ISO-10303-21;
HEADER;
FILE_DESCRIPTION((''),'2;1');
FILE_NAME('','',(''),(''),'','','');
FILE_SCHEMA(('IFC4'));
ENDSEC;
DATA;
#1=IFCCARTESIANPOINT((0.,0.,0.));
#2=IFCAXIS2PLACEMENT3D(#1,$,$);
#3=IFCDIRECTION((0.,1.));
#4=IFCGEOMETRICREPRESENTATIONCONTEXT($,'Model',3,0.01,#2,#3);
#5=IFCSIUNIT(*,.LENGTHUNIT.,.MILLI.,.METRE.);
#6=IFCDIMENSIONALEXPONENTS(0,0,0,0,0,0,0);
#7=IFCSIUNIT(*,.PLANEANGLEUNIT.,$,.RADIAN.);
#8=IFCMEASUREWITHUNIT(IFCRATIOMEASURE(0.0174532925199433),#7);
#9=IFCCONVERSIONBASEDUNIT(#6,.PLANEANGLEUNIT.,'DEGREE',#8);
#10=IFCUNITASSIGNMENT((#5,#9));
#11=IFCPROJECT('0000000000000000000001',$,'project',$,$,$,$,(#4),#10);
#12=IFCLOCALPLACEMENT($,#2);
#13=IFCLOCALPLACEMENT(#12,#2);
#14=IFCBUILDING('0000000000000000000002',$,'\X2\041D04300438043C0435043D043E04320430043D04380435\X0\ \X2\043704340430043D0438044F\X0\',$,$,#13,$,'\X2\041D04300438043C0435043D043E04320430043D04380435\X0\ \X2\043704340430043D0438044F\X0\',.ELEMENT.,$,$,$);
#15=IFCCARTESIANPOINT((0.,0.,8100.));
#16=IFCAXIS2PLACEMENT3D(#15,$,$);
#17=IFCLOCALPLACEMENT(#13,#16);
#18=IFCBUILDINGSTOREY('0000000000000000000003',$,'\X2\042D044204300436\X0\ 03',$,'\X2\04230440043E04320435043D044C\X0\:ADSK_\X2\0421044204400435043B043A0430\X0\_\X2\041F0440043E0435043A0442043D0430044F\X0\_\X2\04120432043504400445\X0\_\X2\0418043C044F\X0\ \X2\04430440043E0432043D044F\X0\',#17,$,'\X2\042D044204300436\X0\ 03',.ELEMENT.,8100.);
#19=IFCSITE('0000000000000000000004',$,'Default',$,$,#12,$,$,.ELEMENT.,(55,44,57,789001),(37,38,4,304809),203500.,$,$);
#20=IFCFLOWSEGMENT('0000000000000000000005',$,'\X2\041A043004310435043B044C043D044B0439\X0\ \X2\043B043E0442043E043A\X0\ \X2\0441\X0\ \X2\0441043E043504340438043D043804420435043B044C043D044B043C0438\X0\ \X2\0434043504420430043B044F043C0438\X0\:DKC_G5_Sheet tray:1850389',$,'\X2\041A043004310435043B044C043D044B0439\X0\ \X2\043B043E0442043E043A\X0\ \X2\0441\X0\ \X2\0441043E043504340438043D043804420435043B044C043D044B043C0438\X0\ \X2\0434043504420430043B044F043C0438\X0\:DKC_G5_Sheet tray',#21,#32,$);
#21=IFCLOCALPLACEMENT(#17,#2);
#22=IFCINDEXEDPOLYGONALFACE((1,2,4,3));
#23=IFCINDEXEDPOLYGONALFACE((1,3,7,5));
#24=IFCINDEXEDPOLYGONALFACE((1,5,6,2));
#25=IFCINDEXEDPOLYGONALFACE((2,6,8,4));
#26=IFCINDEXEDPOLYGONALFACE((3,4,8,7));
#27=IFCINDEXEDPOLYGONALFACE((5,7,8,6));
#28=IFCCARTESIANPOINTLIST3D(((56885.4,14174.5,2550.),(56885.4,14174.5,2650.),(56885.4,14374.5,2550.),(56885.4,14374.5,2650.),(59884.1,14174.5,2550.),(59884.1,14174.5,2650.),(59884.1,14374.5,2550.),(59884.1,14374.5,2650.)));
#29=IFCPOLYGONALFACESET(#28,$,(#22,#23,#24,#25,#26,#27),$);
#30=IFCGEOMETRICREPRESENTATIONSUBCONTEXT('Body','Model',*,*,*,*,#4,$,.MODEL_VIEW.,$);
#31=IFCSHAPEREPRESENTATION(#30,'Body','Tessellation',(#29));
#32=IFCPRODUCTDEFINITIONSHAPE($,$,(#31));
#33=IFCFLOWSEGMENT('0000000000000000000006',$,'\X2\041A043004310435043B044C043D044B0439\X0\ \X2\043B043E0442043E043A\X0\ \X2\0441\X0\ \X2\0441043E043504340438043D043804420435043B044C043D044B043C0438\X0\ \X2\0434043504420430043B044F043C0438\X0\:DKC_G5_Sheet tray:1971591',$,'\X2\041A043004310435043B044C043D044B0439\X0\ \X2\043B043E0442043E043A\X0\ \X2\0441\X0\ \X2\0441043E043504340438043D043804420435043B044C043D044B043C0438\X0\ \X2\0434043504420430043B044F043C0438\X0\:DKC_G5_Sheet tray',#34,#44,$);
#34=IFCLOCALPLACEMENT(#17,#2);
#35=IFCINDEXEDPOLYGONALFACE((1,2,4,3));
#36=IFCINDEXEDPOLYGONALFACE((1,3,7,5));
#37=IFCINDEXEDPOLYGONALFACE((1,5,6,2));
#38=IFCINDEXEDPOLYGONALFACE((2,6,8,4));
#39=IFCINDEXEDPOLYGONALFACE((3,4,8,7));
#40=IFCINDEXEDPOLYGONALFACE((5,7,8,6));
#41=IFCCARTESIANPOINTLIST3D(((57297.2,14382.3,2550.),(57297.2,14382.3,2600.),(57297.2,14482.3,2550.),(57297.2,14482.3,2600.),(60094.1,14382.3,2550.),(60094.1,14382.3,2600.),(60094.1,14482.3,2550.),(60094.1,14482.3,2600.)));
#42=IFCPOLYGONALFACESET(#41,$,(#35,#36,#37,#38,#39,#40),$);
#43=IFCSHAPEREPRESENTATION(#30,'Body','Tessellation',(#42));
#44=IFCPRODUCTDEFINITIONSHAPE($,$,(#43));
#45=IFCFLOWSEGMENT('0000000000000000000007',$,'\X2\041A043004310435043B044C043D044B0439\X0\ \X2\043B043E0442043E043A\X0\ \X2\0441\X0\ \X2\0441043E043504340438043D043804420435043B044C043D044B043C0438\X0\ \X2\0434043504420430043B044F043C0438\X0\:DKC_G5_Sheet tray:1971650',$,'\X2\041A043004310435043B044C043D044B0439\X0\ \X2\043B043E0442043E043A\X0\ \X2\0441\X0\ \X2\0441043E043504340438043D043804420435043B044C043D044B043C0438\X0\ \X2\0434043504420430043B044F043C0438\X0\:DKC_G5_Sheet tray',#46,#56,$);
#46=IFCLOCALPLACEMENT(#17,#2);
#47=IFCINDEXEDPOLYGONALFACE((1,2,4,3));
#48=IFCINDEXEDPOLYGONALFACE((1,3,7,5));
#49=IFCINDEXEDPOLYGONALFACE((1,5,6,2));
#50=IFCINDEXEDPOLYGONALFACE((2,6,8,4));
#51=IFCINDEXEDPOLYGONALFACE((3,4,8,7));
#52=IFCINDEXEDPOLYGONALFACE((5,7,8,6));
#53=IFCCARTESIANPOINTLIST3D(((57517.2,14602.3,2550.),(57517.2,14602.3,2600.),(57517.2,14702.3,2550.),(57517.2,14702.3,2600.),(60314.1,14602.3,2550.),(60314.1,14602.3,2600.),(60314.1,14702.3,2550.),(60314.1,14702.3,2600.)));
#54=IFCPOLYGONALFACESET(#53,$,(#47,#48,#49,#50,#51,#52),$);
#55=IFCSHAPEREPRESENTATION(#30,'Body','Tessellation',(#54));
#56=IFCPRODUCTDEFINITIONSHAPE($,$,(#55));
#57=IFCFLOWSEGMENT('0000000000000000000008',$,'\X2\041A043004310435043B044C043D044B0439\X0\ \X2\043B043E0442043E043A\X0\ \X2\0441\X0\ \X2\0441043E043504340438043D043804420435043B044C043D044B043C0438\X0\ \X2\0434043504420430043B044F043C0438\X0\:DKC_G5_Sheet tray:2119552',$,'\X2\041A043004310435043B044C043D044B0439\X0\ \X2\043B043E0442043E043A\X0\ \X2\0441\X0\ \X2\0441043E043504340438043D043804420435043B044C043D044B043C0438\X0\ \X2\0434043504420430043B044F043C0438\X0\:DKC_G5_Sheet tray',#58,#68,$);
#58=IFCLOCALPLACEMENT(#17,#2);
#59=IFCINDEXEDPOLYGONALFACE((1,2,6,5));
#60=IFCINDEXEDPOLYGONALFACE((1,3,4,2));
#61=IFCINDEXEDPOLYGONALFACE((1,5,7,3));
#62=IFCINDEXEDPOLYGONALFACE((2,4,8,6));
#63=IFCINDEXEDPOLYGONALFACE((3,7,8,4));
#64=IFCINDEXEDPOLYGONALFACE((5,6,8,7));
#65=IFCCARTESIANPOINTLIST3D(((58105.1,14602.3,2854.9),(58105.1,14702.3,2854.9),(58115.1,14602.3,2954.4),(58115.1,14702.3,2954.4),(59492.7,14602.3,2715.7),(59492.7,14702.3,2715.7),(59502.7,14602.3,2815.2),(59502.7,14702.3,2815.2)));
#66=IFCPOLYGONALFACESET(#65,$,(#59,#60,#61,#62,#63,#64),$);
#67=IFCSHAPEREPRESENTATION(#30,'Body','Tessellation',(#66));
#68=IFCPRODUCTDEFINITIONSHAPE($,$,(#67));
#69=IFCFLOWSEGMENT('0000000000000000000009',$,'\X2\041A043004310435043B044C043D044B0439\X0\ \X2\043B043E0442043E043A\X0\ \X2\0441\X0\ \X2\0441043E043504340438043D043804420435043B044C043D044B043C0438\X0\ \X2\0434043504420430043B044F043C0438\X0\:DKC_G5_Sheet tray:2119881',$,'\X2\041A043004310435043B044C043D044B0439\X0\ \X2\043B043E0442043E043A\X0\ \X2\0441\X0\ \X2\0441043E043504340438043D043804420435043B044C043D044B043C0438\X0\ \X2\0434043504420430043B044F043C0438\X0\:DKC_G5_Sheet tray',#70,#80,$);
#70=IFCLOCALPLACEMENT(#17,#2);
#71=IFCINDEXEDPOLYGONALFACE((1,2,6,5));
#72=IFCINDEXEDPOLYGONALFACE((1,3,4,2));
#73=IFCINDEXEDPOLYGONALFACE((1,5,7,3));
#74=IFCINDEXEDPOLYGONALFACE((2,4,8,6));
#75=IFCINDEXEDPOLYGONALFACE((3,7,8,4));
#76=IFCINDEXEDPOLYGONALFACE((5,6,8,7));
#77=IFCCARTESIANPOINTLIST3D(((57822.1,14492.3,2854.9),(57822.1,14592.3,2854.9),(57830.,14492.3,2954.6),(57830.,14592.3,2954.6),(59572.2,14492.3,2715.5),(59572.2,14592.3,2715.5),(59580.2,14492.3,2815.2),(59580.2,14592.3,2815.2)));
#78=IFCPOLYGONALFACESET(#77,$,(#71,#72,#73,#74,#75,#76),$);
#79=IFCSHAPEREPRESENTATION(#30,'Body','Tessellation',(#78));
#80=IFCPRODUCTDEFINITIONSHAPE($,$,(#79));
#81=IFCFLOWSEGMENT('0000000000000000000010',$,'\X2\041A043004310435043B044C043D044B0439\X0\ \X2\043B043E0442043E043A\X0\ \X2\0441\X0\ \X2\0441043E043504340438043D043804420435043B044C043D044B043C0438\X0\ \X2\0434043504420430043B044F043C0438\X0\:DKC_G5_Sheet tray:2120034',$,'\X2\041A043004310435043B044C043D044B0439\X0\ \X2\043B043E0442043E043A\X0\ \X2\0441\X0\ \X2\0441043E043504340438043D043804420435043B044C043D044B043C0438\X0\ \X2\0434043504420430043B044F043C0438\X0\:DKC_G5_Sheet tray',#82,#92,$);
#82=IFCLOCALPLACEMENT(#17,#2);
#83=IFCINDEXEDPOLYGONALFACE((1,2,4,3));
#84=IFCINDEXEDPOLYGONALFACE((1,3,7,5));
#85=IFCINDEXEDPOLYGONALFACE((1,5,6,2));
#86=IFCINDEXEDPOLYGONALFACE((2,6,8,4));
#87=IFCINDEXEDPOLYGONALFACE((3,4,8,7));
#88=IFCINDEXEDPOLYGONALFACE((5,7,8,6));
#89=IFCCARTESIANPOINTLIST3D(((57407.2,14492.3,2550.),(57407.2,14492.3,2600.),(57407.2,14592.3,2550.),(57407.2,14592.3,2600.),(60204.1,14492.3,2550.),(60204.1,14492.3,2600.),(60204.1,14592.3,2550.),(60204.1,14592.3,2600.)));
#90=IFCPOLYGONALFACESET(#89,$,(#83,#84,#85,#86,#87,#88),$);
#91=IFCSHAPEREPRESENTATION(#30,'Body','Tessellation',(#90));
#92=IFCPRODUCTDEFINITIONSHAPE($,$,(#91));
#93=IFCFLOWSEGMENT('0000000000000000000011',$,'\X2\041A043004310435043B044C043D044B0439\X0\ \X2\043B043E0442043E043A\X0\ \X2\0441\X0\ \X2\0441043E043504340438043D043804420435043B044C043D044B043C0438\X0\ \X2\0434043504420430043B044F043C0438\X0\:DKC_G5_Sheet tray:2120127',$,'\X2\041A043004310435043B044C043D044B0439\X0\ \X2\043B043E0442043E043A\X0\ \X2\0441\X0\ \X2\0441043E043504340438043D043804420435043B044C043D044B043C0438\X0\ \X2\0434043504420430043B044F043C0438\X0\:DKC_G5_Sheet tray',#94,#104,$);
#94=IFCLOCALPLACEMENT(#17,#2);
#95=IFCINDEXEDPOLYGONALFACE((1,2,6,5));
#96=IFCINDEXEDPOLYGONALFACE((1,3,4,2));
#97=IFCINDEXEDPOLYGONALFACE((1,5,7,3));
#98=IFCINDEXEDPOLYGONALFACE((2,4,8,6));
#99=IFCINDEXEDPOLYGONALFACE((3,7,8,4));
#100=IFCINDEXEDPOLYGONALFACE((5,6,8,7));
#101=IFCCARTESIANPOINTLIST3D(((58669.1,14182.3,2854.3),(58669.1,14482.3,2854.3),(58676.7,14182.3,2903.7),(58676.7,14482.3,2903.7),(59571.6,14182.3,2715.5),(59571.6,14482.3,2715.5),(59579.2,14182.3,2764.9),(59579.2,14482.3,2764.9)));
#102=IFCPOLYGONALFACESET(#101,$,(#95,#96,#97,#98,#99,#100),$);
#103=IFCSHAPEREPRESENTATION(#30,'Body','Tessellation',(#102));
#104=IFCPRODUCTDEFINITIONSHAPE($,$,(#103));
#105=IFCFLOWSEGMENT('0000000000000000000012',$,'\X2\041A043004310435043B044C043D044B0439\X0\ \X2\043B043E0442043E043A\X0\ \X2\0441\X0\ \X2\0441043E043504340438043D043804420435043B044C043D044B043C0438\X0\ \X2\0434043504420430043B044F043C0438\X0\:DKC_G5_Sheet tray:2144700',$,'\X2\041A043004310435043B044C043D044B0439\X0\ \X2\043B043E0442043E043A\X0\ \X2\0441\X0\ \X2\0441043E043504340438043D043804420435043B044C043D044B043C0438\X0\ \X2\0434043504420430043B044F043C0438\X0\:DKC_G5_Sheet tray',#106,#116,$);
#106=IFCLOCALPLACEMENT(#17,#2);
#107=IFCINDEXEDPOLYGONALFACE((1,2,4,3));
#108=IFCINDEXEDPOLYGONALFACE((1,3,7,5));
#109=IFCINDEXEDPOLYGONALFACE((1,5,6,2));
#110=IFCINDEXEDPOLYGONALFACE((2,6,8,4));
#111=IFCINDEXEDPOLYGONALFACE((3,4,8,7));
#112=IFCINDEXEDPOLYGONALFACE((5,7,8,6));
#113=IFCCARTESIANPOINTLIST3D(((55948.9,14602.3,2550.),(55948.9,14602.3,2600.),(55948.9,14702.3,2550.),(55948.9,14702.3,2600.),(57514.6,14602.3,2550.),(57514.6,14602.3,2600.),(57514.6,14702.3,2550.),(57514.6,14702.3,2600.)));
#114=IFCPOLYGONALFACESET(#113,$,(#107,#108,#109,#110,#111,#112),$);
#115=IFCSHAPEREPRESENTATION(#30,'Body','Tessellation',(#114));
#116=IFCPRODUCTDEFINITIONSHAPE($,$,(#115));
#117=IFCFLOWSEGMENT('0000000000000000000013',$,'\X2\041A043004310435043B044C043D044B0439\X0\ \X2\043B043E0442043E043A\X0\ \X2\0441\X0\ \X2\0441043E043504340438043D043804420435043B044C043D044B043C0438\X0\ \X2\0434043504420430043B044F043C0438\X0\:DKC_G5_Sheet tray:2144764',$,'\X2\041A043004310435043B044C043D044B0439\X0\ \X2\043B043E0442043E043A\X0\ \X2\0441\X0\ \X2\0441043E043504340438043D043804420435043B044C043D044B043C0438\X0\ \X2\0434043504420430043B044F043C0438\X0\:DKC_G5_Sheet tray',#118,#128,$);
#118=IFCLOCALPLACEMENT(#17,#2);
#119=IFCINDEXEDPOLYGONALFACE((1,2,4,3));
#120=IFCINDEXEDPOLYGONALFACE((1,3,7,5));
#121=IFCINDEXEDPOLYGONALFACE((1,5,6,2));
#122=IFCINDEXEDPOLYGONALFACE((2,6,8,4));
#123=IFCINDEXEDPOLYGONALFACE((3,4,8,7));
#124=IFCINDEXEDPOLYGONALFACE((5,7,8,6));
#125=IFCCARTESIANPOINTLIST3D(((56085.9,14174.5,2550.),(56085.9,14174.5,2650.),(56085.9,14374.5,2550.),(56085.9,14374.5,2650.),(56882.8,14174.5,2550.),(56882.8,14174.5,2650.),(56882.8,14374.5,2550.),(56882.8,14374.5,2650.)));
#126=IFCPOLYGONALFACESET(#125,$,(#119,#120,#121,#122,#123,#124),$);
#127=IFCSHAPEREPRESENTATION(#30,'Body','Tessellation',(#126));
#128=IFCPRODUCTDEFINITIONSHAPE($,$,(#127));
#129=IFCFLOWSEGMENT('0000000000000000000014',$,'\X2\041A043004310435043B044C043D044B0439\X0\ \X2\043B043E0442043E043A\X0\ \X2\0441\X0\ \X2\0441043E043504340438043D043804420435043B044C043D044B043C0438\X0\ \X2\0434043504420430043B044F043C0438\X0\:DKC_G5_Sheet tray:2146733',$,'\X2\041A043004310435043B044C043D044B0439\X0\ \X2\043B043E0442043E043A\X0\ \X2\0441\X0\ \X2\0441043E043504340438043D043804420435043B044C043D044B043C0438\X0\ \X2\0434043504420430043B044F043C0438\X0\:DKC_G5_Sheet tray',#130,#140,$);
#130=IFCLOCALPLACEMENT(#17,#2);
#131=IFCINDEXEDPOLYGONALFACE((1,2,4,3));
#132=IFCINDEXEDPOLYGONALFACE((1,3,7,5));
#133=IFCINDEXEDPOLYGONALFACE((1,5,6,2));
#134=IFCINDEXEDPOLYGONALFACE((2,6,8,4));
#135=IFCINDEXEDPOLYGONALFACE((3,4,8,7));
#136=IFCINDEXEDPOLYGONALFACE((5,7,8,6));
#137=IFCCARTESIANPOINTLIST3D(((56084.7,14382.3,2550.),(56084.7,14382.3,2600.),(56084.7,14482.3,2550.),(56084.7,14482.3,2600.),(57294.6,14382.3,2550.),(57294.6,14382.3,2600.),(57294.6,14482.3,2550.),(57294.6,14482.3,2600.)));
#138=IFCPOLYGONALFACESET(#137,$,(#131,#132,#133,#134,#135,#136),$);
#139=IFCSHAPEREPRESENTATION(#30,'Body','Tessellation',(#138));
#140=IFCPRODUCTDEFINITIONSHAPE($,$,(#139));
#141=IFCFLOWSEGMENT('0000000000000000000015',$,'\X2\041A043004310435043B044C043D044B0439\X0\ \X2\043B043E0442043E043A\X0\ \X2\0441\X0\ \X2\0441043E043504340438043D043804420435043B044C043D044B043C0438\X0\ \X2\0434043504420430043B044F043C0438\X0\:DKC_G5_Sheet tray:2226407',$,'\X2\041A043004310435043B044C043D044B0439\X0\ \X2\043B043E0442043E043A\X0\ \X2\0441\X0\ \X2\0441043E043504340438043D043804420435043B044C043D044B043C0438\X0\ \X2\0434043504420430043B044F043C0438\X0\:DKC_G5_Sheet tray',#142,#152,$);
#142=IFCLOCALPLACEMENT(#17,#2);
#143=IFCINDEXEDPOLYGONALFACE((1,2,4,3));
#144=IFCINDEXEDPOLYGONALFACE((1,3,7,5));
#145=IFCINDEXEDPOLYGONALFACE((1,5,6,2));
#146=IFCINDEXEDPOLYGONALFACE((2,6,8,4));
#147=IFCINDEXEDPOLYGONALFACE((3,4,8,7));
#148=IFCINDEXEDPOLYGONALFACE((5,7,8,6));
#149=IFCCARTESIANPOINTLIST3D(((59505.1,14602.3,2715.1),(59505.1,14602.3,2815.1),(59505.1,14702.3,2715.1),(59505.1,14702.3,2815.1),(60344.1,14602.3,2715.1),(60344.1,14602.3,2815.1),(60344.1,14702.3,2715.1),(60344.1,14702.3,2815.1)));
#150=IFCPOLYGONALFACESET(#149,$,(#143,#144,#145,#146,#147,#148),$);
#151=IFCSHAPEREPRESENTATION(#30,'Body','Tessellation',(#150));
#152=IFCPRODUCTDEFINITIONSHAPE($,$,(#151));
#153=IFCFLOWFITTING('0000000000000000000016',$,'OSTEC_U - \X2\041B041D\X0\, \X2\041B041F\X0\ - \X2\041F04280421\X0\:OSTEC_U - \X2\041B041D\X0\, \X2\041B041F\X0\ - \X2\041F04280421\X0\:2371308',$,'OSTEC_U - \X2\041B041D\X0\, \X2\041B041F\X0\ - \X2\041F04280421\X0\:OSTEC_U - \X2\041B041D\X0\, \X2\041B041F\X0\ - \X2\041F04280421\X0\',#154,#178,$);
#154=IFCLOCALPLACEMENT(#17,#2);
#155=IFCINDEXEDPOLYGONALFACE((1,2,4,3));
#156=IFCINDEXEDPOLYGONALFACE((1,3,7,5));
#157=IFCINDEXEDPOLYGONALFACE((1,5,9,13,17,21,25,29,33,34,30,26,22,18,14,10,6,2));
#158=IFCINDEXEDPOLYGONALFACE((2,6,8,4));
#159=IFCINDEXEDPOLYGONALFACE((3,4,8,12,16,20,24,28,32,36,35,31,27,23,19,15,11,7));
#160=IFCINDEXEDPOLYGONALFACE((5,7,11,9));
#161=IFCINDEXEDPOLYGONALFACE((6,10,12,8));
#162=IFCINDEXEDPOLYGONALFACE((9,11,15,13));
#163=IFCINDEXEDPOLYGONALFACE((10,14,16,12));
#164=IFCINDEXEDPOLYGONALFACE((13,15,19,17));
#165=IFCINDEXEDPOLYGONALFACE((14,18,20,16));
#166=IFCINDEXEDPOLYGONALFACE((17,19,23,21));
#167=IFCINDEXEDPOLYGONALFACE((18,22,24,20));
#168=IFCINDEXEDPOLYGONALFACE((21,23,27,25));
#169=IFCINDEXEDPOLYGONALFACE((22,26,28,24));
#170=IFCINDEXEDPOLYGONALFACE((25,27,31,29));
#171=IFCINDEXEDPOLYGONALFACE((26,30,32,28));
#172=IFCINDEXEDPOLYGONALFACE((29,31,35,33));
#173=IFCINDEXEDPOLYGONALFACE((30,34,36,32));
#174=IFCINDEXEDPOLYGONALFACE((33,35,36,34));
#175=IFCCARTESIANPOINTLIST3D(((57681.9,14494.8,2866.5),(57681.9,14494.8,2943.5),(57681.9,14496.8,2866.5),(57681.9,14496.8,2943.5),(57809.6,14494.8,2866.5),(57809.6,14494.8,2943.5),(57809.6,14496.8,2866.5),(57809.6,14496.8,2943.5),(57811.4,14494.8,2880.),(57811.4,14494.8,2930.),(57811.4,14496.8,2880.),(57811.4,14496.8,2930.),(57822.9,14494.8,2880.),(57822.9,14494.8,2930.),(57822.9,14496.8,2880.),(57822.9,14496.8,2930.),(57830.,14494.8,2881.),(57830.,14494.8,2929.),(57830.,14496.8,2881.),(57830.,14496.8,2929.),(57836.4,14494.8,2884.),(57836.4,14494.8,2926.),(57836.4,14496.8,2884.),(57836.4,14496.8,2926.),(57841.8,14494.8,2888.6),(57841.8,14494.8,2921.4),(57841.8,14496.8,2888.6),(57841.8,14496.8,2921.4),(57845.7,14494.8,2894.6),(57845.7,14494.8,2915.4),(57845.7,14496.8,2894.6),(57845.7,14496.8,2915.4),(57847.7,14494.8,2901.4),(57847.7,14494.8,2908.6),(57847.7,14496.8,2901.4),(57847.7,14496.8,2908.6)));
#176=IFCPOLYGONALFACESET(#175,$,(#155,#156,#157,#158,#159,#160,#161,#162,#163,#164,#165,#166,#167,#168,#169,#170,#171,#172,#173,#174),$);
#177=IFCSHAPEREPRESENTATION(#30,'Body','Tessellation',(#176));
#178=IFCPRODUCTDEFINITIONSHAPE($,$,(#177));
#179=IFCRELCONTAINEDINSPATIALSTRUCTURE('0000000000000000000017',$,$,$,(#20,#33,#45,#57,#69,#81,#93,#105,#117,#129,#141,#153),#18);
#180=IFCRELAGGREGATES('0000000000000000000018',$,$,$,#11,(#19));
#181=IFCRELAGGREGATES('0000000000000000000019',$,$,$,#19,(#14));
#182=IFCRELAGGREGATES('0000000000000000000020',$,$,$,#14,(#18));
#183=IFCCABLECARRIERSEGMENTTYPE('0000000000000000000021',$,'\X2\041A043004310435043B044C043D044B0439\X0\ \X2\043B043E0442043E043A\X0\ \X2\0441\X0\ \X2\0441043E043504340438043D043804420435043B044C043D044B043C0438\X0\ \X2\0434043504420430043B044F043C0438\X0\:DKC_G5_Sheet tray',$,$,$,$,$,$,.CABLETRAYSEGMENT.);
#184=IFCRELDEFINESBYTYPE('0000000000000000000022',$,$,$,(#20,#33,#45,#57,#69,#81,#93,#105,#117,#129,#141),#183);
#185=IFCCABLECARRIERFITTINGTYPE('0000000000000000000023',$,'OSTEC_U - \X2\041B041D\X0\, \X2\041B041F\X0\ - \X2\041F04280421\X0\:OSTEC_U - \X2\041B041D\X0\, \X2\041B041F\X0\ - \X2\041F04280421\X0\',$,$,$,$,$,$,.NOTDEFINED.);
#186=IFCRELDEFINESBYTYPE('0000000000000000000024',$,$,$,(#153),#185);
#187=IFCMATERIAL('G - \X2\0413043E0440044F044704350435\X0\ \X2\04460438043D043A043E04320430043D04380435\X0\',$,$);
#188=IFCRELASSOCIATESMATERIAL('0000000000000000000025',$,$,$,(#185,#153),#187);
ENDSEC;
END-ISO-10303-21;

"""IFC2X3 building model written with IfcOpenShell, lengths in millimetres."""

from ifc_helpers import new_model, entity, si_unit, converted_unit, direction, frame, frame_2d, origin, origin_2d_with_axis, place, context, subcontext, project, spatial, polyline, circle_curve, parameter, trimmed, segment, composite_curve, rectangle, outline, extrude, source, transform, mapped, material, type_object, type_shapes, element, save


model = new_model("IFC2X3")

# Units and contexts
model_context = context("Model", 3, precision=0.01, world=origin(), true_north=direction((0.0, 1.0)))
body_context = subcontext(model_context, "Body", "Model", "MODEL_VIEW")
ifc_project = project(units=[si_unit("LENGTHUNIT", "METRE", prefix="MILLI"), converted_unit("PLANEANGLEUNIT", "DEGREE", entity("IfcRatioMeasure", 0.0174532925199433), si_unit("PLANEANGLEUNIT", "RADIAN"), dimensions=[0, 0, 0, 0, 0, 0, 0])], contexts=[model_context])

# Site, building, storey
site_placement = place(None, frame((0.0, 0.0, 0.0)))
site = spatial("IfcSite", under=ifc_project, at=site_placement, Name="Default", CompositionType="ELEMENT", RefLatitude=(55, 44, 57, 789001), RefLongitude=(37, 38, 4, 304809), RefElevation=203500.0)
building_placement = place(site_placement, origin())
building = spatial("IfcBuilding", under=site, at=building_placement, Name="Наименование здания", LongName="Наименование здания", CompositionType="ELEMENT")
storey_placement = place(building_placement, frame((0.0, 0.0, 8100.0)))
storey = spatial("IfcBuildingStorey", under=building, at=storey_placement, Name="Этаж 03", ObjectType="Уровень:ADSK_Стрелка_Проектная_Вверх_Имя уровня", LongName="Этаж 03", CompositionType="ELEMENT", Elevation=8100.0)

# Flow segments
cable_carrier_segment_type = type_object("IfcCableCarrierSegmentType", Name="Кабельный лоток с соединительными деталями:DKC_G5_Sheet tray", PredefinedType="CABLETRAYSEGMENT")
flow_segment_1_placement = place(storey_placement, frame((56885.4, 14174.5, 2550.0)))
element("IfcFlowSegment", 1, at=flow_segment_1_placement, inside=storey, type_object=cable_carrier_segment_type, Name="Кабельный лоток с соединительными деталями:DKC_G5_Sheet tray:1850389", ObjectType="Кабельный лоток с соединительными деталями:DKC_G5_Sheet tray", context=body_context, shape_type="SweptSolid", body=[
    extrude(rectangle(XDim=2998.7, YDim=200.0, at=frame_2d((0.0, 0.0), x_axis=(1.0, 0.0))), frame((1499.4, 100.0, 0.0)), (0.0, 0.0, 1.0), 100.0),
])
flow_segment_2_placement = place(storey_placement, frame((57297.2, 14382.3, 2550.0)))
element("IfcFlowSegment", 2, at=flow_segment_2_placement, inside=storey, type_object=cable_carrier_segment_type, Name="Кабельный лоток с соединительными деталями:DKC_G5_Sheet tray:1971591", ObjectType="Кабельный лоток с соединительными деталями:DKC_G5_Sheet tray", context=body_context, shape_type="SweptSolid", body=[
    extrude(rectangle(XDim=2796.9, YDim=100.0, at=frame_2d((0.0, 0.0), x_axis=(1.0, 0.0))), frame((1398.5, 50.0, 0.0), z_axis=(0.0, 0.0, 1.0), x_axis=(-1.0, 0.0, 0.0)), (0.0, 0.0, 1.0), 50.0),
])
flow_segment_3_placement = place(storey_placement, frame((57517.2, 14602.3, 2550.0)))
element("IfcFlowSegment", 3, at=flow_segment_3_placement, inside=storey, type_object=cable_carrier_segment_type, Name="Кабельный лоток с соединительными деталями:DKC_G5_Sheet tray:1971650", ObjectType="Кабельный лоток с соединительными деталями:DKC_G5_Sheet tray", context=body_context, shape_type="SweptSolid", body=[
    extrude(rectangle(XDim=2796.9, YDim=100.0, at=frame_2d((0.0, 0.0), x_axis=(1.0, 0.0))), frame((1398.5, 50.0, 0.0), z_axis=(0.0, 0.0, 1.0), x_axis=(-1.0, 0.0, 0.0)), (0.0, 0.0, 1.0), 50.0),
])
flow_segment_4_placement = place(storey_placement, frame((58105.1, 14602.3, 2715.7)))
element("IfcFlowSegment", 4, at=flow_segment_4_placement, inside=storey, type_object=cable_carrier_segment_type, Name="Кабельный лоток с соединительными деталями:DKC_G5_Sheet tray:2119552", ObjectType="Кабельный лоток с соединительными деталями:DKC_G5_Sheet tray", context=body_context, shape_type="SweptSolid", body=[
    extrude(rectangle(XDim=100.0, YDim=100.0, at=frame_2d((0.0, 0.0), x_axis=(0.0, 1.0))), frame((5.0, 50.0, 188.9), z_axis=(0.995009, 0.0, -0.099785), x_axis=(0.0, 1.0, 0.0)), (0.0, 0.0, 1.0), 1394.6),
])
flow_segment_5_placement = place(storey_placement, frame((57822.1, 14492.3, 2715.5)))
element("IfcFlowSegment", 5, at=flow_segment_5_placement, inside=storey, type_object=cable_carrier_segment_type, Name="Кабельный лоток с соединительными деталями:DKC_G5_Sheet tray:2119881", ObjectType="Кабельный лоток с соединительными деталями:DKC_G5_Sheet tray", context=body_context, shape_type="SweptSolid", body=[
    extrude(rectangle(XDim=100.0, YDim=100.0, at=frame_2d((0.0, 0.0), x_axis=(0.0, 1.0))), frame((4.0, 50.0, 189.3), z_axis=(0.996841, 0.0, -0.079421), x_axis=(0.0, 1.0, 0.0)), (0.0, 0.0, 1.0), 1755.7),
])
flow_segment_6_placement = place(storey_placement, frame((57407.2, 14492.3, 2550.0)))
element("IfcFlowSegment", 6, at=flow_segment_6_placement, inside=storey, type_object=cable_carrier_segment_type, Name="Кабельный лоток с соединительными деталями:DKC_G5_Sheet tray:2120034", ObjectType="Кабельный лоток с соединительными деталями:DKC_G5_Sheet tray", context=body_context, shape_type="SweptSolid", body=[
    extrude(rectangle(XDim=2796.9, YDim=100.0, at=frame_2d((0.0, 0.0), x_axis=(1.0, 0.0))), frame((1398.5, 50.0, 0.0), z_axis=(0.0, 0.0, 1.0), x_axis=(-1.0, 0.0, 0.0)), (0.0, 0.0, 1.0), 50.0),
])
flow_segment_7_placement = place(storey_placement, frame((58669.1, 14182.3, 2715.5)))
element("IfcFlowSegment", 7, at=flow_segment_7_placement, inside=storey, type_object=cable_carrier_segment_type, Name="Кабельный лоток с соединительными деталями:DKC_G5_Sheet tray:2120127", ObjectType="Кабельный лоток с соединительными деталями:DKC_G5_Sheet tray", context=body_context, shape_type="SweptSolid", body=[
    extrude(rectangle(XDim=50.0, YDim=300.0, at=origin_2d_with_axis()), frame((3.8, 150.0, 163.5), z_axis=(0.988381, 0.0, -0.151999), x_axis=(0.151999, 0.0, 0.988381)), (0.0, 0.0, 1.0), 913.2),
])
flow_segment_8_placement = place(storey_placement, frame((55948.9, 14602.3, 2550.0)))
element("IfcFlowSegment", 8, at=flow_segment_8_placement, inside=storey, type_object=cable_carrier_segment_type, Name="Кабельный лоток с соединительными деталями:DKC_G5_Sheet tray:2144700", ObjectType="Кабельный лоток с соединительными деталями:DKC_G5_Sheet tray", context=body_context, shape_type="SweptSolid", body=[
    extrude(rectangle(XDim=1565.7, YDim=100.0, at=frame_2d((0.0, 0.0), x_axis=(1.0, 0.0))), frame((782.8, 50.0, 0.0), z_axis=(0.0, 0.0, 1.0), x_axis=(-1.0, 0.0, 0.0)), (0.0, 0.0, 1.0), 50.0),
])
flow_segment_9_placement = place(storey_placement, frame((56085.9, 14174.5, 2550.0)))
element("IfcFlowSegment", 9, at=flow_segment_9_placement, inside=storey, type_object=cable_carrier_segment_type, Name="Кабельный лоток с соединительными деталями:DKC_G5_Sheet tray:2144764", ObjectType="Кабельный лоток с соединительными деталями:DKC_G5_Sheet tray", context=body_context, shape_type="SweptSolid", body=[
    extrude(rectangle(XDim=796.9, YDim=200.0, at=frame_2d((0.0, 0.0), x_axis=(1.0, 0.0))), frame((398.5, 100.0, 0.0), z_axis=(0.0, 0.0, 1.0), x_axis=(-1.0, 0.0, 0.0)), (0.0, 0.0, 1.0), 100.0),
])
flow_segment_10_placement = place(storey_placement, frame((56084.7, 14382.3, 2550.0)))
element("IfcFlowSegment", 10, at=flow_segment_10_placement, inside=storey, type_object=cable_carrier_segment_type, Name="Кабельный лоток с соединительными деталями:DKC_G5_Sheet tray:2146733", ObjectType="Кабельный лоток с соединительными деталями:DKC_G5_Sheet tray", context=body_context, shape_type="SweptSolid", body=[
    extrude(rectangle(XDim=1209.9, YDim=100.0, at=origin_2d_with_axis()), frame((604.9, 50.0, 0.0), z_axis=(0.0, 0.0, 1.0), x_axis=(-1.0, 0.0, 0.0)), (0.0, 0.0, 1.0), 50.0),
])
flow_segment_11_placement = place(storey_placement, frame((59505.1, 14602.3, 2715.1)))
element("IfcFlowSegment", 11, at=flow_segment_11_placement, inside=storey, type_object=cable_carrier_segment_type, Name="Кабельный лоток с соединительными деталями:DKC_G5_Sheet tray:2226407", ObjectType="Кабельный лоток с соединительными деталями:DKC_G5_Sheet tray", context=body_context, shape_type="SweptSolid", body=[
    extrude(rectangle(XDim=839.0, YDim=100.0, at=frame_2d((0.0, 0.0), x_axis=(1.0, 0.0))), frame((419.5, 50.0, 0.0)), (0.0, 0.0, 1.0), 100.0),
])

# Flow fitting
ifc_material = material(Name="G - Горячее цинкование")
cable_carrier_fitting_type_1 = type_object("IfcCableCarrierFittingType", Name="OSTEC_U - ЛН, ЛП - ПШС:OSTEC_U - ЛН, ЛП - ПШС", PredefinedType="NOTDEFINED", material=ifc_material)
shared_shape_1 = source(origin(), body_context, "Body", "SweptSolid", [
    extrude(outline(composite_curve([segment(trimmed(circle_curve(frame_2d((-41.5, 0.0), x_axis=(1.0, 0.0)), 25.0), [parameter(90.0)], [parameter(270.0)], True, "PARAMETER"), True, "CONTINUOUS"), segment(polyline([(-41.5, -25.0), (-30.0, -25.0)]), True, "CONTINUOUS"), segment(polyline([(-30.0, -25.0), (-28.1, -38.5)]), True, "CONTINUOUS"), segment(polyline([(-28.1, -38.5), (99.5, -38.5)]), True, "CONTINUOUS"), segment(polyline([(99.5, -38.5), (99.5, 38.5)]), True, "CONTINUOUS"), segment(polyline([(99.5, 38.5), (-28.1, 38.5)]), True, "CONTINUOUS"), segment(polyline([(-28.1, 38.5), (-30.0, 25.0)]), True, "CONTINUOUS"), segment(polyline([(-30.0, 25.0), (-41.5, 25.0)]), True, "CONTINUOUS")], self_intersect=False)), frame((41.5, 0.0, 0.0), z_axis=(0.0, 0.0, -1.0), x_axis=(1.0, 0.0, 0.0)), (0.0, 0.0, -1.0), 2.0),
])
type_shapes(cable_carrier_fitting_type_1, [shared_shape_1])
for number, where, z_axis, x_axis, name in (
    (12, (57822.9, 14496.8, 2905.0), (0.0, -1.0, 0.0), (-1.0, 0.0, 0.0), "OSTEC_U - ЛН, ЛП - ПШС:OSTEC_U - ЛН, ЛП - ПШС:2371308"),
):
    element("IfcFlowFitting", number, at=place(storey_placement, frame(where, z_axis=z_axis, x_axis=x_axis)), inside=storey, type_object=cable_carrier_fitting_type_1, material=ifc_material, Name=name, ObjectType="OSTEC_U - ЛН, ЛП - ПШС:OSTEC_U - ЛН, ЛП - ПШС", context=body_context, shape_type="MappedRepresentation", body=[
        mapped(shared_shape_1, transform((0.0, 0.0, 0.0), scale=1.0)),
    ])

save(model, "model.ifc")
